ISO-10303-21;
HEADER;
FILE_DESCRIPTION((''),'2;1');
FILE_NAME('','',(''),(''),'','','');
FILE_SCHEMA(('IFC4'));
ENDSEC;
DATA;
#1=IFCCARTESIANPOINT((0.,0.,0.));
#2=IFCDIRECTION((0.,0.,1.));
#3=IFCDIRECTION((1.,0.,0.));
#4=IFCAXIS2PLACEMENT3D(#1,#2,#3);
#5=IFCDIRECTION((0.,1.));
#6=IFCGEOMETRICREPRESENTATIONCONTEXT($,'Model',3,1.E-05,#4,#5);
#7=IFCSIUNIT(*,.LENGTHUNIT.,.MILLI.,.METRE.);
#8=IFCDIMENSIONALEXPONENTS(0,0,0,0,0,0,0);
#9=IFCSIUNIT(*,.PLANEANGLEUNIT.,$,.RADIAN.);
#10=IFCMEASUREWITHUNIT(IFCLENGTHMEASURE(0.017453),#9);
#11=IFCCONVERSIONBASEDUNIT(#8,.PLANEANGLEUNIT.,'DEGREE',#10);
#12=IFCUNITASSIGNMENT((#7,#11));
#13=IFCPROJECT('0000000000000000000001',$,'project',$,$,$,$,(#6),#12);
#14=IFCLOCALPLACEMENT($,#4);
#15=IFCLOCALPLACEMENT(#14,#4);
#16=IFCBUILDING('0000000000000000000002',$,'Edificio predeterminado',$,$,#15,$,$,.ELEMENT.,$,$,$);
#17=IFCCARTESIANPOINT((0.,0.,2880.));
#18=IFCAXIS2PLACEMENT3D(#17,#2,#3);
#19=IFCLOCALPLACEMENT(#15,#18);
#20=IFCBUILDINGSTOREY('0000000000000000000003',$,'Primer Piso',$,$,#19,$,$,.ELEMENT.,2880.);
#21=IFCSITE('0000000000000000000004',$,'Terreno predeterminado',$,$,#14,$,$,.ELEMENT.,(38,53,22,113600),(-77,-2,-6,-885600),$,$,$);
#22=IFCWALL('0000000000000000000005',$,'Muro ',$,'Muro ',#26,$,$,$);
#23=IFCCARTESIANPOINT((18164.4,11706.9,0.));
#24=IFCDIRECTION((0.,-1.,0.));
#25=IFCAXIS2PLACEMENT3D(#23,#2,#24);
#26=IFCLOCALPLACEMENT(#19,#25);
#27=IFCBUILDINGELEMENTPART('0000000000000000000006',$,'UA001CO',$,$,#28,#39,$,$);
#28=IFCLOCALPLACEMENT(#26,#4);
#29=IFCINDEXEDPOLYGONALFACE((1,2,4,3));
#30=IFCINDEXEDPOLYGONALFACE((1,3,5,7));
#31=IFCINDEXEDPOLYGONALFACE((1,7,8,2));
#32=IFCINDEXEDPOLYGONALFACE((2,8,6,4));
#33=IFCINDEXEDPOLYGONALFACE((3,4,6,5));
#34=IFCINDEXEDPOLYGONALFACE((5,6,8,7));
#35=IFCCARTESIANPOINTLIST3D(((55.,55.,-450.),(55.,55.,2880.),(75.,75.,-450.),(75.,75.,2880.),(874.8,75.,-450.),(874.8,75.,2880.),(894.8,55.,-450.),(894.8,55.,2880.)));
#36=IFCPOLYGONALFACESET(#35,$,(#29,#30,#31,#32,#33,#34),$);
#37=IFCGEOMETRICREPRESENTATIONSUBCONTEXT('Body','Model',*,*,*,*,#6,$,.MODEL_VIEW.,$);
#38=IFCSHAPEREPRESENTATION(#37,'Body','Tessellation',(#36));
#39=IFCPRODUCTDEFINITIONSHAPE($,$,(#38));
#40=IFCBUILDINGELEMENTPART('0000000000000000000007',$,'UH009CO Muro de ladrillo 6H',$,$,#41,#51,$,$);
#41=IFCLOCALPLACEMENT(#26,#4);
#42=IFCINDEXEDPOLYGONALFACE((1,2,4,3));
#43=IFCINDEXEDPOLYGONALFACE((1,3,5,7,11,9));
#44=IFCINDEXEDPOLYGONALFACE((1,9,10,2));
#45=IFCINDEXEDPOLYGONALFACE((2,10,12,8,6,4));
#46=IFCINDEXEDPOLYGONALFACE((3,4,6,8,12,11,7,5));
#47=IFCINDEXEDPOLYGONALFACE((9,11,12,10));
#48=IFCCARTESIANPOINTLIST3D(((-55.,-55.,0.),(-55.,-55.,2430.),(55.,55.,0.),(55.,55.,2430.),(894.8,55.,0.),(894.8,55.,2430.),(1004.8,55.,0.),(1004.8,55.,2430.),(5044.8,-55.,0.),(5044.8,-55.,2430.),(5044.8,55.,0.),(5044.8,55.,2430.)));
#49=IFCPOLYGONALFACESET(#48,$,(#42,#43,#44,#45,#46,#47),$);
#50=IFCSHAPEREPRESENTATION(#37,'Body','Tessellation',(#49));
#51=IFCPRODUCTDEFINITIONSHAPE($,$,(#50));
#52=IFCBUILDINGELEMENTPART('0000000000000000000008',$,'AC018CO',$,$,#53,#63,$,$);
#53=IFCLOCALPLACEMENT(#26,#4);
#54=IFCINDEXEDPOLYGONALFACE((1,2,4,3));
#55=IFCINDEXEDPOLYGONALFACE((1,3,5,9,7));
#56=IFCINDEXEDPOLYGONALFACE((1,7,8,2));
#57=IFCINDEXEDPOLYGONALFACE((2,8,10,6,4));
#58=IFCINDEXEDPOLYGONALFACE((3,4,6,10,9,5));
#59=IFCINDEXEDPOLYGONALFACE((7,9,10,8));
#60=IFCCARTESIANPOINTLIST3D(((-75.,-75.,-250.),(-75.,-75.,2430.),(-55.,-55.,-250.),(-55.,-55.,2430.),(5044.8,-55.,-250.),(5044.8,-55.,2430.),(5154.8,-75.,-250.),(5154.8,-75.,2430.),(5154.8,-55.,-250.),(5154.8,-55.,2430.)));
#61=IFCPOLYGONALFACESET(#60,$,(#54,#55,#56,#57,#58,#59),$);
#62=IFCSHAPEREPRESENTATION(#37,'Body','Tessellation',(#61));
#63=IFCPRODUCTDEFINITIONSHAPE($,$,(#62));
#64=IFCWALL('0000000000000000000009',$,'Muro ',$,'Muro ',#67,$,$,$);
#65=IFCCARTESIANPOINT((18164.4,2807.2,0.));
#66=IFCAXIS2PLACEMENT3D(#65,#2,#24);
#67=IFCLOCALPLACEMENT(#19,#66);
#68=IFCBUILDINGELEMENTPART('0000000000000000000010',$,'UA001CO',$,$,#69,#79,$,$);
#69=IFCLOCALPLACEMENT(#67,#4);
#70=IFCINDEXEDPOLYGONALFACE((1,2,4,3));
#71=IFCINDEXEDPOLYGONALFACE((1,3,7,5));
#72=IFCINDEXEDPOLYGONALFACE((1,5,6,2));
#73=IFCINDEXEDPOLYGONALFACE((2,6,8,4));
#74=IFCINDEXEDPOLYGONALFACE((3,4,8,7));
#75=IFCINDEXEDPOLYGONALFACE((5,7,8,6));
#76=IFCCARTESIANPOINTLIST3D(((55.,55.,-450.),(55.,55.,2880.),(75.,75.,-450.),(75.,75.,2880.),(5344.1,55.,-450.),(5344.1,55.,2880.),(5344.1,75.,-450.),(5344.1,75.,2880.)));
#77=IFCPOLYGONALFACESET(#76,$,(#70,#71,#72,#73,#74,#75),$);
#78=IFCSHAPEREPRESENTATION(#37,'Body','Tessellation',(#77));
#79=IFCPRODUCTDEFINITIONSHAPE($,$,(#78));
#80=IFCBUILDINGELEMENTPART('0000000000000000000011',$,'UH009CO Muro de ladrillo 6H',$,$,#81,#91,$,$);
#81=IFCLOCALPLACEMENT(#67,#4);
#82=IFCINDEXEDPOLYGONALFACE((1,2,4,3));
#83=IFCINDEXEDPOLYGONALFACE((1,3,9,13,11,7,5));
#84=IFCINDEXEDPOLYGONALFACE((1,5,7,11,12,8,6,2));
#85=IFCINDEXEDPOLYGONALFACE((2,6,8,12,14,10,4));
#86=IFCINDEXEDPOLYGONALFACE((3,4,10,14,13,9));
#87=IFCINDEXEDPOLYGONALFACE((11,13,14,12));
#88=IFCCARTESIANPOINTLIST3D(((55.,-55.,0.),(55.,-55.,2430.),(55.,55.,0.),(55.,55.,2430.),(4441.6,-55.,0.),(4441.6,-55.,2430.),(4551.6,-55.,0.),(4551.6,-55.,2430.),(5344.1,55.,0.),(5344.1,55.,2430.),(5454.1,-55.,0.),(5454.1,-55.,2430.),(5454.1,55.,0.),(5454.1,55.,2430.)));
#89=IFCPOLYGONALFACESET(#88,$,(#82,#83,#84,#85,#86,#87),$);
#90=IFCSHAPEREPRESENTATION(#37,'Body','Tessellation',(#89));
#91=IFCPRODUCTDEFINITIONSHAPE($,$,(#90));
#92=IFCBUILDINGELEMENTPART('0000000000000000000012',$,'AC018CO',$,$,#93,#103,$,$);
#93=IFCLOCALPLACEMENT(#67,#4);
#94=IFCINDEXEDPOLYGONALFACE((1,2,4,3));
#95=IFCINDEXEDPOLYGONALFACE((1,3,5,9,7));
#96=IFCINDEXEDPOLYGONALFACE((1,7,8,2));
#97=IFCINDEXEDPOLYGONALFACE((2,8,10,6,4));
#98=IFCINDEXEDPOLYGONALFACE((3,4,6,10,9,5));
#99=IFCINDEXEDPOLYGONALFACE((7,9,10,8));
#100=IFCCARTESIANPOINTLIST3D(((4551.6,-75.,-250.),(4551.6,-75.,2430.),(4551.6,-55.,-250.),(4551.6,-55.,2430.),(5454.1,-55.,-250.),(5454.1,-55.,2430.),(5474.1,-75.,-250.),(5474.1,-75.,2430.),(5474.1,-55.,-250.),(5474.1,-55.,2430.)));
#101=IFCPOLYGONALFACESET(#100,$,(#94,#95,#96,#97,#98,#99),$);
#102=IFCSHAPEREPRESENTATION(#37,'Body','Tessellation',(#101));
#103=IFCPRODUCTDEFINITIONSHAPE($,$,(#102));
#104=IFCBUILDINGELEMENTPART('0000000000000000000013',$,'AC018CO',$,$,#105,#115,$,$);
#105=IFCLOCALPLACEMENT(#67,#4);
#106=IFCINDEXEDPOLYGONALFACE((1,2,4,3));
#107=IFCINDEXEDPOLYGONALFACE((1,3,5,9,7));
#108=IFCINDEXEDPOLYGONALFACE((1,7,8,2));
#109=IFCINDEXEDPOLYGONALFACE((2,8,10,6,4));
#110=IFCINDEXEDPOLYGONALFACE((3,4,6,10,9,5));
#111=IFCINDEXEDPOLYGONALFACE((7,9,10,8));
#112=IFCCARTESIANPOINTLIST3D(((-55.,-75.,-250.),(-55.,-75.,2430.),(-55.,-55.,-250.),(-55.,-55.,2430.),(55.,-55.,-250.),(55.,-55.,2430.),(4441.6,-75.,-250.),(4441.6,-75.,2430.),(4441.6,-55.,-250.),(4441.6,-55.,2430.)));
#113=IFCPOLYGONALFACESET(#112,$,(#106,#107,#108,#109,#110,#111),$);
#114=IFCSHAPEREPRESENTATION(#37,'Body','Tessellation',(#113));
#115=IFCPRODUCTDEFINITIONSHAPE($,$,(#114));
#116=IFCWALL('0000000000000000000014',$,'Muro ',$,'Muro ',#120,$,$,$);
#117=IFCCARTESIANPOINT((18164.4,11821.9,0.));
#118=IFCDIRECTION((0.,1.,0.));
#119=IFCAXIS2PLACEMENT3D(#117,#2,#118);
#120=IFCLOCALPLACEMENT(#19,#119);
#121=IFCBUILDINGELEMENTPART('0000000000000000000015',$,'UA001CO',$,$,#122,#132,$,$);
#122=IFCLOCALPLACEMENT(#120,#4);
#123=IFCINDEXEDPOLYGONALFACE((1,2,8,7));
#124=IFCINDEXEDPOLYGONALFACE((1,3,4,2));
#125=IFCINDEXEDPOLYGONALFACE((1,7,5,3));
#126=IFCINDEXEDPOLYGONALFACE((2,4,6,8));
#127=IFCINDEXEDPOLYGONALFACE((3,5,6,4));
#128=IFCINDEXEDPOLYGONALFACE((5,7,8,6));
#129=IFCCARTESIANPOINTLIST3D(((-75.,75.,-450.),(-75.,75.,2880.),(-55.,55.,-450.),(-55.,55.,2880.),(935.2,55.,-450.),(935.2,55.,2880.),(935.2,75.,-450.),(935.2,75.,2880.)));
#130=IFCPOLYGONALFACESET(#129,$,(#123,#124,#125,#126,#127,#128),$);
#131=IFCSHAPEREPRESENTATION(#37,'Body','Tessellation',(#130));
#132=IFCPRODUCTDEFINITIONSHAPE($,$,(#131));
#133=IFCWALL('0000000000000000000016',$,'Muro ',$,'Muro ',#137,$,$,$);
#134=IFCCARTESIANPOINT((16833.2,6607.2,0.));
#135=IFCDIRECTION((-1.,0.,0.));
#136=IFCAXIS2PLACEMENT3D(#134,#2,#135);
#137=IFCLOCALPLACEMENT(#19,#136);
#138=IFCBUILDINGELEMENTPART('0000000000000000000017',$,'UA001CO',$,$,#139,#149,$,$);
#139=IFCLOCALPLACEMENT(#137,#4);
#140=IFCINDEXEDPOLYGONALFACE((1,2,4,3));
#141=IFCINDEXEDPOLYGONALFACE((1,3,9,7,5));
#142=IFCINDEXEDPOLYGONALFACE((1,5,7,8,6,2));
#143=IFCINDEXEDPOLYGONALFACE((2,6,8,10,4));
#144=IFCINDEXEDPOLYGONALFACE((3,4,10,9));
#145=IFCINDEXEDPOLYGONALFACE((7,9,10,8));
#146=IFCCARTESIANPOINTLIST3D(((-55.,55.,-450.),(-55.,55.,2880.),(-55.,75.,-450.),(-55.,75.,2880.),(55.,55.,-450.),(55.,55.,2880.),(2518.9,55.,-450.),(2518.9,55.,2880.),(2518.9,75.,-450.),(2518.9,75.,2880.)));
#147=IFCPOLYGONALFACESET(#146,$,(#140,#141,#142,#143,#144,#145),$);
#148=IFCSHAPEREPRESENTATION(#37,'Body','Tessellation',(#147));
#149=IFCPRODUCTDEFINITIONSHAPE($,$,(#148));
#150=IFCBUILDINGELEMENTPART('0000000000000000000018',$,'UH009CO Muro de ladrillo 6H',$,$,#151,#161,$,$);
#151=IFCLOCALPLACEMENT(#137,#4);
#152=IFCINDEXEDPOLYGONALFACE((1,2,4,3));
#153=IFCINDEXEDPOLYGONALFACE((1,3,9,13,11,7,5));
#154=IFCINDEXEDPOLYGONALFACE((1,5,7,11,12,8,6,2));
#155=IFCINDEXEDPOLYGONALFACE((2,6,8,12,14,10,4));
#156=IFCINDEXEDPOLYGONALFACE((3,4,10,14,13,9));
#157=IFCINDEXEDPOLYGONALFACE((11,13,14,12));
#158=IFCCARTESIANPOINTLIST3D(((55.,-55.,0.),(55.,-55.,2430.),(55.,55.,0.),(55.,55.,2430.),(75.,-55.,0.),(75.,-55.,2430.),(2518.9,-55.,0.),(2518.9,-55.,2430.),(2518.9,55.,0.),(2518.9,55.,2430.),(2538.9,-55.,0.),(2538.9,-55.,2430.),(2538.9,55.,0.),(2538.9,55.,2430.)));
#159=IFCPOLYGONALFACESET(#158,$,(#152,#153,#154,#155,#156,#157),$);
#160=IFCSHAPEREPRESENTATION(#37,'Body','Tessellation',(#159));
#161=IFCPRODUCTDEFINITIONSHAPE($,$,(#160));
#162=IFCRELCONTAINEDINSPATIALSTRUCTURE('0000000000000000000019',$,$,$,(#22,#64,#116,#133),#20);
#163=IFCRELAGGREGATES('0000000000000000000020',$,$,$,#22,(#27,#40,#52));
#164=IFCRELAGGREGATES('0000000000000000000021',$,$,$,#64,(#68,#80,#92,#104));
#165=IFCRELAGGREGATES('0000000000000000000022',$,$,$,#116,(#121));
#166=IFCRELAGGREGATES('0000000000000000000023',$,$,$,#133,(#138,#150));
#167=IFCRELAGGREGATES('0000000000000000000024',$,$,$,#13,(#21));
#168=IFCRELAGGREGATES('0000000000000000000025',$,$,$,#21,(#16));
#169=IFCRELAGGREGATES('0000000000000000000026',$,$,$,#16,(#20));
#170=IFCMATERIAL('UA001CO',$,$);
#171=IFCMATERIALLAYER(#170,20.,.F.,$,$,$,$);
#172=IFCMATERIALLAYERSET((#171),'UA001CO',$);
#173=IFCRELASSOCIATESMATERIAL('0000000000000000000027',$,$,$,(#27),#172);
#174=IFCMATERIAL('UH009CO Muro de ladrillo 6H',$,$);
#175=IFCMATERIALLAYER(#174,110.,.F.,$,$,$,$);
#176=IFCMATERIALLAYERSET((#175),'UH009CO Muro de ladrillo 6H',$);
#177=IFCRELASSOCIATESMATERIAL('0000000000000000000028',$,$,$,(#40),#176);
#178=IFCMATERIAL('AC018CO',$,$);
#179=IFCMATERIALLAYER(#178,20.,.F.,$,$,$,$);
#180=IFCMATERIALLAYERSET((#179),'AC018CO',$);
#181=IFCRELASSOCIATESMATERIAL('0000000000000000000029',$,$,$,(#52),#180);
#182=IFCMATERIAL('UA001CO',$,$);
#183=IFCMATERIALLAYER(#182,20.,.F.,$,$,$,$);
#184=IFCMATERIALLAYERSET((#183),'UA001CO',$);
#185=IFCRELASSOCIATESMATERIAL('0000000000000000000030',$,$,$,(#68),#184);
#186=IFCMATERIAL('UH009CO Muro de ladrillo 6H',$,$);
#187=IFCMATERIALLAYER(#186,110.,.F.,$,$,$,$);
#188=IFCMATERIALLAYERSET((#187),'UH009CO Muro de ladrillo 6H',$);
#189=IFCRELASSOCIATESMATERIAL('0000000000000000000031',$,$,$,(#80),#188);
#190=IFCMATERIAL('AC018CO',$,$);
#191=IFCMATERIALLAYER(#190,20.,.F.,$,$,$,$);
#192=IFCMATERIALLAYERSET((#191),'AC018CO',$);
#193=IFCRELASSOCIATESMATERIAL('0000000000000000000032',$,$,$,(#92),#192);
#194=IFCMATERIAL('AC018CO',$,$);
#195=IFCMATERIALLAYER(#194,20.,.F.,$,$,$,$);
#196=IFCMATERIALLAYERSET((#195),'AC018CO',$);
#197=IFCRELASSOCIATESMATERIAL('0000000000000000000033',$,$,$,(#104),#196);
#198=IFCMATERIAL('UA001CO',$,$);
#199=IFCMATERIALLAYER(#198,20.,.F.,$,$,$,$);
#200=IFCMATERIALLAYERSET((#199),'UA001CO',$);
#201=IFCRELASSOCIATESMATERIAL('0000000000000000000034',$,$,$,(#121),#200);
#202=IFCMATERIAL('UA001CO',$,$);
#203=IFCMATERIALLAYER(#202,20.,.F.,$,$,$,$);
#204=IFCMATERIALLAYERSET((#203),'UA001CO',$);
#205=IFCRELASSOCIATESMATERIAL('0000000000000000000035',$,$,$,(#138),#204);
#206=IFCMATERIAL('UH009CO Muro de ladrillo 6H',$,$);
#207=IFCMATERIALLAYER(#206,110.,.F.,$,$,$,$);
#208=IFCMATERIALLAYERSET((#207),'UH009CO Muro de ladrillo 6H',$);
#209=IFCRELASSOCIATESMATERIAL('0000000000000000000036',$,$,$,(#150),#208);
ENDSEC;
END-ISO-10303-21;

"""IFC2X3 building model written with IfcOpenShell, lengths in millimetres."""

from ifc_helpers import new_model, entity, si_unit, converted_unit, direction, frame, origin_with_axes, place, context, subcontext, project, spatial, polyline, outline, extrude, material, layer, layer_set, layer_usage, element, aggregate, save


model = new_model("IFC2X3")

# Units and contexts
model_context = context("Model", 3, precision=1e-05, world=origin_with_axes(), true_north=direction((0.0, 1.0)))
body_context = subcontext(model_context, "Body", "Model", "MODEL_VIEW")
ifc_project = project(units=[si_unit("LENGTHUNIT", "METRE", prefix="MILLI"), converted_unit("PLANEANGLEUNIT", "DEGREE", entity("IfcLengthMeasure", 0.017453), si_unit("PLANEANGLEUNIT", "RADIAN"), dimensions=[0, 0, 0, 0, 0, 0, 0])], contexts=[model_context])

# Site, building, storey
site_placement = place(None, origin_with_axes())
site = spatial("IfcSite", under=ifc_project, at=site_placement, Name="Terreno predeterminado", CompositionType="ELEMENT", RefLatitude=(38, 53, 22, 113600), RefLongitude=(-77, -2, -6, -885600))
building_placement = place(site_placement, origin_with_axes())
building = spatial("IfcBuilding", under=site, at=building_placement, Name="Edificio predeterminado", CompositionType="ELEMENT")
storey_placement = place(building_placement, frame((0.0, 0.0, 2880.0), z_axis=(0.0, 0.0, 1.0), x_axis=(1.0, 0.0, 0.0)))
storey = spatial("IfcBuildingStorey", under=building, at=storey_placement, Name="Primer Piso", CompositionType="ELEMENT", Elevation=2880.0)

# Walls, building element parts
wall_1_placement = place(storey_placement, frame((18164.4, 11706.9, 0.0), z_axis=(0.0, 0.0, 1.0), x_axis=(0.0, -1.0, 0.0)))
wall_1 = element("IfcWall", 1, at=wall_1_placement, inside=storey, Name="Muro ", ObjectType="Muro ")
ifc_material_1 = material(Name="UA001CO")
ifc_layer_1 = layer(ifc_material_1, 20.0, ventilated=False)
ifc_layer_set_1 = layer_set([ifc_layer_1], Name="UA001CO")
ifc_layer_usage_1 = layer_usage(ifc_layer_set_1, "AXIS2", "NEGATIVE", -75.0)
building_element_part_1_placement = place(wall_1_placement, origin_with_axes())
building_element_part_1 = element("IfcBuildingElementPart", 2, at=building_element_part_1_placement, material=ifc_layer_usage_1, Name="UA001CO", context=body_context, shape_type="SweptSolid", body=[
    extrude(outline(polyline([(874.8, 75.0), (894.8, 55.0), (55.0, 55.0), (75.0, 75.0), (874.8, 75.0)])), frame((0.0, 0.0, -450.0), z_axis=(0.0, 0.0, 1.0), x_axis=(1.0, 0.0, 0.0)), (0.0, 0.0, 1.0), 3330.0),
])
ifc_material_2 = material(Name="UH009CO Muro de ladrillo 6H")
ifc_layer_2 = layer(ifc_material_2, 110.0, ventilated=False)
ifc_layer_set_2 = layer_set([ifc_layer_2], Name="UH009CO Muro de ladrillo 6H")
ifc_layer_usage_2 = layer_usage(ifc_layer_set_2, "AXIS2", "NEGATIVE", -55.0)
building_element_part_2_placement = place(wall_1_placement, origin_with_axes())
building_element_part_2 = element("IfcBuildingElementPart", 3, at=building_element_part_2_placement, material=ifc_layer_usage_2, Name="UH009CO Muro de ladrillo 6H", context=body_context, shape_type="SweptSolid", body=[
    extrude(outline(polyline([(5044.8, 55.0), (5044.8, -55.0), (-55.0, -55.0), (55.0, 55.0), (894.8, 55.0), (1004.8, 55.0), (5044.8, 55.0)])), origin_with_axes(), (0.0, 0.0, 1.0), 2430.0),
])
ifc_material_3 = material(Name="AC018CO")
ifc_layer_3 = layer(ifc_material_3, 20.0, ventilated=False)
ifc_layer_set_3 = layer_set([ifc_layer_3], Name="AC018CO")
ifc_layer_usage_3 = layer_usage(ifc_layer_set_3, "AXIS2", "NEGATIVE", 55.0)
building_element_part_3_placement = place(wall_1_placement, origin_with_axes())
building_element_part_3 = element("IfcBuildingElementPart", 4, at=building_element_part_3_placement, material=ifc_layer_usage_3, Name="AC018CO", context=body_context, shape_type="SweptSolid", body=[
    extrude(outline(polyline([(5154.8, -55.0), (5154.8, -75.0), (-75.0, -75.0), (-55.0, -55.0), (5044.8, -55.0), (5154.8, -55.0)])), frame((0.0, 0.0, -250.0), z_axis=(0.0, 0.0, 1.0), x_axis=(1.0, 0.0, 0.0)), (0.0, 0.0, 1.0), 2680.0),
])
aggregate(wall_1, [building_element_part_1, building_element_part_2, building_element_part_3])
wall_2_placement = place(storey_placement, frame((18164.4, 2807.2, 0.0), z_axis=(0.0, 0.0, 1.0), x_axis=(0.0, -1.0, 0.0)))
wall_2 = element("IfcWall", 5, at=wall_2_placement, inside=storey, Name="Muro ", ObjectType="Muro ")
ifc_material_4 = material(Name="UA001CO")
ifc_layer_4 = layer(ifc_material_4, 20.0, ventilated=False)
ifc_layer_set_4 = layer_set([ifc_layer_4], Name="UA001CO")
ifc_layer_usage_4 = layer_usage(ifc_layer_set_4, "AXIS2", "NEGATIVE", -75.0)
building_element_part_4_placement = place(wall_2_placement, origin_with_axes())
building_element_part_4 = element("IfcBuildingElementPart", 6, at=building_element_part_4_placement, material=ifc_layer_usage_4, Name="UA001CO", context=body_context, shape_type="SweptSolid", body=[
    extrude(outline(polyline([(5344.1, 75.0), (5344.1, 55.0), (55.0, 55.0), (75.0, 75.0), (5344.1, 75.0)])), frame((0.0, 0.0, -450.0), z_axis=(0.0, 0.0, 1.0), x_axis=(1.0, 0.0, 0.0)), (0.0, 0.0, 1.0), 3330.0),
])
ifc_material_5 = material(Name="UH009CO Muro de ladrillo 6H")
ifc_layer_5 = layer(ifc_material_5, 110.0, ventilated=False)
ifc_layer_set_5 = layer_set([ifc_layer_5], Name="UH009CO Muro de ladrillo 6H")
ifc_layer_usage_5 = layer_usage(ifc_layer_set_5, "AXIS2", "NEGATIVE", -55.0)
building_element_part_5_placement = place(wall_2_placement, origin_with_axes())
building_element_part_5 = element("IfcBuildingElementPart", 7, at=building_element_part_5_placement, material=ifc_layer_usage_5, Name="UH009CO Muro de ladrillo 6H", context=body_context, shape_type="SweptSolid", body=[
    extrude(outline(polyline([(5454.1, 55.0), (5454.1, -55.0), (4551.6, -55.0), (4441.6, -55.0), (55.0, -55.0), (55.0, 55.0), (5344.1, 55.0), (5454.1, 55.0)])), origin_with_axes(), (0.0, 0.0, 1.0), 2430.0),
])
ifc_material_6 = material(Name="AC018CO")
ifc_layer_6 = layer(ifc_material_6, 20.0, ventilated=False)
ifc_layer_set_6 = layer_set([ifc_layer_6], Name="AC018CO")
ifc_layer_usage_6 = layer_usage(ifc_layer_set_6, "AXIS2", "NEGATIVE", 55.0)
building_element_part_6_placement = place(wall_2_placement, origin_with_axes())
building_element_part_6 = element("IfcBuildingElementPart", 8, at=building_element_part_6_placement, material=ifc_layer_usage_6, Name="AC018CO", context=body_context, shape_type="SweptSolid", body=[
    extrude(outline(polyline([(5474.1, -55.0), (5474.1, -75.0), (4551.6, -75.0), (4551.6, -55.0), (5454.1, -55.0), (5474.1, -55.0)])), frame((0.0, 0.0, -250.0), z_axis=(0.0, 0.0, 1.0), x_axis=(1.0, 0.0, 0.0)), (0.0, 0.0, 1.0), 2680.0),
])
ifc_material_7 = material(Name="AC018CO")
ifc_layer_7 = layer(ifc_material_7, 20.0, ventilated=False)
ifc_layer_set_7 = layer_set([ifc_layer_7], Name="AC018CO")
ifc_layer_usage_7 = layer_usage(ifc_layer_set_7, "AXIS2", "NEGATIVE", 55.0)
building_element_part_7_placement = place(wall_2_placement, origin_with_axes())
building_element_part_7 = element("IfcBuildingElementPart", 9, at=building_element_part_7_placement, material=ifc_layer_usage_7, Name="AC018CO", context=body_context, shape_type="SweptSolid", body=[
    extrude(outline(polyline([(4441.6, -55.0), (4441.6, -75.0), (-55.0, -75.0), (-55.0, -55.0), (55.0, -55.0), (4441.6, -55.0)])), frame((0.0, 0.0, -250.0), z_axis=(0.0, 0.0, 1.0), x_axis=(1.0, 0.0, 0.0)), (0.0, 0.0, 1.0), 2680.0),
])
aggregate(wall_2, [building_element_part_4, building_element_part_5, building_element_part_6, building_element_part_7])

# Wall, building element part
wall_3_placement = place(storey_placement, frame((18164.4, 11821.9, 0.0), z_axis=(0.0, 0.0, 1.0), x_axis=(0.0, 1.0, 0.0)))
wall_3 = element("IfcWall", 10, at=wall_3_placement, inside=storey, Name="Muro ", ObjectType="Muro ")
ifc_material_8 = material(Name="UA001CO")
ifc_layer_8 = layer(ifc_material_8, 20.0, ventilated=False)
ifc_layer_set_8 = layer_set([ifc_layer_8], Name="UA001CO")
ifc_layer_usage_8 = layer_usage(ifc_layer_set_8, "AXIS2", "NEGATIVE", -75.0)
building_element_part_8_placement = place(wall_3_placement, origin_with_axes())
building_element_part_8 = element("IfcBuildingElementPart", 11, at=building_element_part_8_placement, material=ifc_layer_usage_8, Name="UA001CO", context=body_context, shape_type="SweptSolid", body=[
    extrude(outline(polyline([(935.2, 75.0), (935.2, 55.0), (-55.0, 55.0), (-75.0, 75.0), (935.2, 75.0)])), frame((0.0, 0.0, -450.0), z_axis=(0.0, 0.0, 1.0), x_axis=(1.0, 0.0, 0.0)), (0.0, 0.0, 1.0), 3330.0),
])
aggregate(wall_3, [building_element_part_8])

# Wall, building element parts
wall_4_placement = place(storey_placement, frame((16833.2, 6607.2, 0.0), z_axis=(0.0, 0.0, 1.0), x_axis=(-1.0, 0.0, 0.0)))
wall_4 = element("IfcWall", 12, at=wall_4_placement, inside=storey, Name="Muro ", ObjectType="Muro ")
ifc_material_9 = material(Name="UA001CO")
ifc_layer_9 = layer(ifc_material_9, 20.0, ventilated=False)
ifc_layer_set_9 = layer_set([ifc_layer_9], Name="UA001CO")
ifc_layer_usage_9 = layer_usage(ifc_layer_set_9, "AXIS2", "NEGATIVE", -75.0)
building_element_part_9_placement = place(wall_4_placement, origin_with_axes())
building_element_part_9 = element("IfcBuildingElementPart", 13, at=building_element_part_9_placement, material=ifc_layer_usage_9, Name="UA001CO", context=body_context, shape_type="SweptSolid", body=[
    extrude(outline(polyline([(2518.9, 75.0), (2518.9, 55.0), (55.0, 55.0), (-55.0, 55.0), (-55.0, 75.0), (2518.9, 75.0)])), frame((0.0, 0.0, -450.0), z_axis=(0.0, 0.0, 1.0), x_axis=(1.0, 0.0, 0.0)), (0.0, 0.0, 1.0), 3330.0),
])
ifc_material_10 = material(Name="UH009CO Muro de ladrillo 6H")
ifc_layer_10 = layer(ifc_material_10, 110.0, ventilated=False)
ifc_layer_set_10 = layer_set([ifc_layer_10], Name="UH009CO Muro de ladrillo 6H")
ifc_layer_usage_10 = layer_usage(ifc_layer_set_10, "AXIS2", "NEGATIVE", -55.0)
building_element_part_10_placement = place(wall_4_placement, origin_with_axes())
building_element_part_10 = element("IfcBuildingElementPart", 14, at=building_element_part_10_placement, material=ifc_layer_usage_10, Name="UH009CO Muro de ladrillo 6H", context=body_context, shape_type="SweptSolid", body=[
    extrude(outline(polyline([(2538.9, 55.0), (2538.9, -55.0), (2518.9, -55.0), (75.0, -55.0), (55.0, -55.0), (55.0, 55.0), (2518.9, 55.0), (2538.9, 55.0)])), origin_with_axes(), (0.0, 0.0, 1.0), 2430.0),
])
aggregate(wall_4, [building_element_part_9, building_element_part_10])

save(model, "model.ifc")
